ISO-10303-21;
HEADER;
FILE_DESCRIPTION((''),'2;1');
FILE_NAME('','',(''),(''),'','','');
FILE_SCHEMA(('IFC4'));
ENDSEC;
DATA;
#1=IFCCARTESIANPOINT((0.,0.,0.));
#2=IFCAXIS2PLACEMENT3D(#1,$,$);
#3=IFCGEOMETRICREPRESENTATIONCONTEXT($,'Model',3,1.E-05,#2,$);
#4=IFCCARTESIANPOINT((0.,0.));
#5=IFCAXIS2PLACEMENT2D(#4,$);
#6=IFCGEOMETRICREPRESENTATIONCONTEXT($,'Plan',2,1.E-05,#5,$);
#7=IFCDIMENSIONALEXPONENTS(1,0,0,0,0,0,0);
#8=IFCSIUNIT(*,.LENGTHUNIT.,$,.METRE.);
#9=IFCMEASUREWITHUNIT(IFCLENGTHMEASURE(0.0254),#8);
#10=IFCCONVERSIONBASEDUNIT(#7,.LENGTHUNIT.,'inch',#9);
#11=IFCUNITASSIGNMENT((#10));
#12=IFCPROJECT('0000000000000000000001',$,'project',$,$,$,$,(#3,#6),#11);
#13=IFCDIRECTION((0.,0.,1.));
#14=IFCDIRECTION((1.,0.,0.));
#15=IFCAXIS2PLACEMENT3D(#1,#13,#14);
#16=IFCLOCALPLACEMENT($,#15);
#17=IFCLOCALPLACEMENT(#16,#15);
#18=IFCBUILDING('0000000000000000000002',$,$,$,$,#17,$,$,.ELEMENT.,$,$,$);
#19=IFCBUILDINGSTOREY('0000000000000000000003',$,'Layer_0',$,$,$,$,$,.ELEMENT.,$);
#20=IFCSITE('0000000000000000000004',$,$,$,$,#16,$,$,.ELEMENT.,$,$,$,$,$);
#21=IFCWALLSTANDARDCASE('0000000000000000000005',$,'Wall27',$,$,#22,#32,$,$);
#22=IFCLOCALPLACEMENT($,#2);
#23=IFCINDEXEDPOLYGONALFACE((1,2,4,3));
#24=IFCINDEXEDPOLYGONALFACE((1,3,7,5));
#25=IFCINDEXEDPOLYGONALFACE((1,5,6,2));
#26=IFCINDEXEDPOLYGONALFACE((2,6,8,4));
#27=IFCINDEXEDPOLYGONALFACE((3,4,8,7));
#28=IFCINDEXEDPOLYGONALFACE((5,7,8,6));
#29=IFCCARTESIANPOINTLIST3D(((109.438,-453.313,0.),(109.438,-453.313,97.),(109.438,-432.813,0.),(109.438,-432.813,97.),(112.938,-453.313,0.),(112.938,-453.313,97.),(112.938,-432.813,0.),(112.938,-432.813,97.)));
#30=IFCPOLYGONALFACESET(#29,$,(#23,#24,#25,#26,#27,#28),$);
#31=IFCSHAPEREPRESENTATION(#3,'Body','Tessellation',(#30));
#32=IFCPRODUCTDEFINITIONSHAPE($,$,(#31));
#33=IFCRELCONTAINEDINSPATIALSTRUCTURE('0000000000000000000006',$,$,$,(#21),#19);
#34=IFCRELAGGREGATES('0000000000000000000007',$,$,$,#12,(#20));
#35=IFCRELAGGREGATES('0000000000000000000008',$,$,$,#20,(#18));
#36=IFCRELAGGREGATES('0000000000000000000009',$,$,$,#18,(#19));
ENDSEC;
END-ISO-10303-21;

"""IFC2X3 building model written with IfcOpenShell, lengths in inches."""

from ifc_helpers import new_model, entity, si_unit, converted_unit, frame, origin, origin_with_axes, origin_2d, place, context, project, spatial, polyline, outline, extrude, element, save


model = new_model("IFC2X3")

# Units and contexts
model_context = context("Model", 3, precision=1e-05, world=origin())
plan_context = context("Plan", 2, precision=1e-05, world=origin_2d())
ifc_project = project(units=[converted_unit("LENGTHUNIT", "inch", entity("IfcLengthMeasure", 0.0254), si_unit("LENGTHUNIT", "METRE"), dimensions=[1, 0, 0, 0, 0, 0, 0])], contexts=[model_context, plan_context])

# Site, building, storey
site_placement = place(None, origin_with_axes())
site = spatial("IfcSite", under=ifc_project, at=site_placement, CompositionType="ELEMENT")
building_placement = place(site_placement, origin_with_axes())
building = spatial("IfcBuilding", under=site, at=building_placement, CompositionType="ELEMENT")
storey = spatial("IfcBuildingStorey", under=building, Name="Layer_0", CompositionType="ELEMENT")

# Shared definitions
placement = place(building_placement, origin_with_axes())

# Wall
wall_1_placement = place(placement, frame((111.188, -453.312, 0.0), z_axis=(0.0, 0.0, 1.0), x_axis=(0.0, 1.0, 0.0)))
element("IfcWallStandardCase", 1, at=wall_1_placement, inside=storey, Name="Wall27", context=model_context, shape_type="SweptSolid", body=[
    extrude(outline(polyline([(0.0, -1.75), (0.0, 1.75), (20.5, 1.75), (20.5, -1.75), (0.0, -1.75)])), origin(), (0.0, 0.0, 1.0), 97.0),
])

save(model, "model.ifc")
